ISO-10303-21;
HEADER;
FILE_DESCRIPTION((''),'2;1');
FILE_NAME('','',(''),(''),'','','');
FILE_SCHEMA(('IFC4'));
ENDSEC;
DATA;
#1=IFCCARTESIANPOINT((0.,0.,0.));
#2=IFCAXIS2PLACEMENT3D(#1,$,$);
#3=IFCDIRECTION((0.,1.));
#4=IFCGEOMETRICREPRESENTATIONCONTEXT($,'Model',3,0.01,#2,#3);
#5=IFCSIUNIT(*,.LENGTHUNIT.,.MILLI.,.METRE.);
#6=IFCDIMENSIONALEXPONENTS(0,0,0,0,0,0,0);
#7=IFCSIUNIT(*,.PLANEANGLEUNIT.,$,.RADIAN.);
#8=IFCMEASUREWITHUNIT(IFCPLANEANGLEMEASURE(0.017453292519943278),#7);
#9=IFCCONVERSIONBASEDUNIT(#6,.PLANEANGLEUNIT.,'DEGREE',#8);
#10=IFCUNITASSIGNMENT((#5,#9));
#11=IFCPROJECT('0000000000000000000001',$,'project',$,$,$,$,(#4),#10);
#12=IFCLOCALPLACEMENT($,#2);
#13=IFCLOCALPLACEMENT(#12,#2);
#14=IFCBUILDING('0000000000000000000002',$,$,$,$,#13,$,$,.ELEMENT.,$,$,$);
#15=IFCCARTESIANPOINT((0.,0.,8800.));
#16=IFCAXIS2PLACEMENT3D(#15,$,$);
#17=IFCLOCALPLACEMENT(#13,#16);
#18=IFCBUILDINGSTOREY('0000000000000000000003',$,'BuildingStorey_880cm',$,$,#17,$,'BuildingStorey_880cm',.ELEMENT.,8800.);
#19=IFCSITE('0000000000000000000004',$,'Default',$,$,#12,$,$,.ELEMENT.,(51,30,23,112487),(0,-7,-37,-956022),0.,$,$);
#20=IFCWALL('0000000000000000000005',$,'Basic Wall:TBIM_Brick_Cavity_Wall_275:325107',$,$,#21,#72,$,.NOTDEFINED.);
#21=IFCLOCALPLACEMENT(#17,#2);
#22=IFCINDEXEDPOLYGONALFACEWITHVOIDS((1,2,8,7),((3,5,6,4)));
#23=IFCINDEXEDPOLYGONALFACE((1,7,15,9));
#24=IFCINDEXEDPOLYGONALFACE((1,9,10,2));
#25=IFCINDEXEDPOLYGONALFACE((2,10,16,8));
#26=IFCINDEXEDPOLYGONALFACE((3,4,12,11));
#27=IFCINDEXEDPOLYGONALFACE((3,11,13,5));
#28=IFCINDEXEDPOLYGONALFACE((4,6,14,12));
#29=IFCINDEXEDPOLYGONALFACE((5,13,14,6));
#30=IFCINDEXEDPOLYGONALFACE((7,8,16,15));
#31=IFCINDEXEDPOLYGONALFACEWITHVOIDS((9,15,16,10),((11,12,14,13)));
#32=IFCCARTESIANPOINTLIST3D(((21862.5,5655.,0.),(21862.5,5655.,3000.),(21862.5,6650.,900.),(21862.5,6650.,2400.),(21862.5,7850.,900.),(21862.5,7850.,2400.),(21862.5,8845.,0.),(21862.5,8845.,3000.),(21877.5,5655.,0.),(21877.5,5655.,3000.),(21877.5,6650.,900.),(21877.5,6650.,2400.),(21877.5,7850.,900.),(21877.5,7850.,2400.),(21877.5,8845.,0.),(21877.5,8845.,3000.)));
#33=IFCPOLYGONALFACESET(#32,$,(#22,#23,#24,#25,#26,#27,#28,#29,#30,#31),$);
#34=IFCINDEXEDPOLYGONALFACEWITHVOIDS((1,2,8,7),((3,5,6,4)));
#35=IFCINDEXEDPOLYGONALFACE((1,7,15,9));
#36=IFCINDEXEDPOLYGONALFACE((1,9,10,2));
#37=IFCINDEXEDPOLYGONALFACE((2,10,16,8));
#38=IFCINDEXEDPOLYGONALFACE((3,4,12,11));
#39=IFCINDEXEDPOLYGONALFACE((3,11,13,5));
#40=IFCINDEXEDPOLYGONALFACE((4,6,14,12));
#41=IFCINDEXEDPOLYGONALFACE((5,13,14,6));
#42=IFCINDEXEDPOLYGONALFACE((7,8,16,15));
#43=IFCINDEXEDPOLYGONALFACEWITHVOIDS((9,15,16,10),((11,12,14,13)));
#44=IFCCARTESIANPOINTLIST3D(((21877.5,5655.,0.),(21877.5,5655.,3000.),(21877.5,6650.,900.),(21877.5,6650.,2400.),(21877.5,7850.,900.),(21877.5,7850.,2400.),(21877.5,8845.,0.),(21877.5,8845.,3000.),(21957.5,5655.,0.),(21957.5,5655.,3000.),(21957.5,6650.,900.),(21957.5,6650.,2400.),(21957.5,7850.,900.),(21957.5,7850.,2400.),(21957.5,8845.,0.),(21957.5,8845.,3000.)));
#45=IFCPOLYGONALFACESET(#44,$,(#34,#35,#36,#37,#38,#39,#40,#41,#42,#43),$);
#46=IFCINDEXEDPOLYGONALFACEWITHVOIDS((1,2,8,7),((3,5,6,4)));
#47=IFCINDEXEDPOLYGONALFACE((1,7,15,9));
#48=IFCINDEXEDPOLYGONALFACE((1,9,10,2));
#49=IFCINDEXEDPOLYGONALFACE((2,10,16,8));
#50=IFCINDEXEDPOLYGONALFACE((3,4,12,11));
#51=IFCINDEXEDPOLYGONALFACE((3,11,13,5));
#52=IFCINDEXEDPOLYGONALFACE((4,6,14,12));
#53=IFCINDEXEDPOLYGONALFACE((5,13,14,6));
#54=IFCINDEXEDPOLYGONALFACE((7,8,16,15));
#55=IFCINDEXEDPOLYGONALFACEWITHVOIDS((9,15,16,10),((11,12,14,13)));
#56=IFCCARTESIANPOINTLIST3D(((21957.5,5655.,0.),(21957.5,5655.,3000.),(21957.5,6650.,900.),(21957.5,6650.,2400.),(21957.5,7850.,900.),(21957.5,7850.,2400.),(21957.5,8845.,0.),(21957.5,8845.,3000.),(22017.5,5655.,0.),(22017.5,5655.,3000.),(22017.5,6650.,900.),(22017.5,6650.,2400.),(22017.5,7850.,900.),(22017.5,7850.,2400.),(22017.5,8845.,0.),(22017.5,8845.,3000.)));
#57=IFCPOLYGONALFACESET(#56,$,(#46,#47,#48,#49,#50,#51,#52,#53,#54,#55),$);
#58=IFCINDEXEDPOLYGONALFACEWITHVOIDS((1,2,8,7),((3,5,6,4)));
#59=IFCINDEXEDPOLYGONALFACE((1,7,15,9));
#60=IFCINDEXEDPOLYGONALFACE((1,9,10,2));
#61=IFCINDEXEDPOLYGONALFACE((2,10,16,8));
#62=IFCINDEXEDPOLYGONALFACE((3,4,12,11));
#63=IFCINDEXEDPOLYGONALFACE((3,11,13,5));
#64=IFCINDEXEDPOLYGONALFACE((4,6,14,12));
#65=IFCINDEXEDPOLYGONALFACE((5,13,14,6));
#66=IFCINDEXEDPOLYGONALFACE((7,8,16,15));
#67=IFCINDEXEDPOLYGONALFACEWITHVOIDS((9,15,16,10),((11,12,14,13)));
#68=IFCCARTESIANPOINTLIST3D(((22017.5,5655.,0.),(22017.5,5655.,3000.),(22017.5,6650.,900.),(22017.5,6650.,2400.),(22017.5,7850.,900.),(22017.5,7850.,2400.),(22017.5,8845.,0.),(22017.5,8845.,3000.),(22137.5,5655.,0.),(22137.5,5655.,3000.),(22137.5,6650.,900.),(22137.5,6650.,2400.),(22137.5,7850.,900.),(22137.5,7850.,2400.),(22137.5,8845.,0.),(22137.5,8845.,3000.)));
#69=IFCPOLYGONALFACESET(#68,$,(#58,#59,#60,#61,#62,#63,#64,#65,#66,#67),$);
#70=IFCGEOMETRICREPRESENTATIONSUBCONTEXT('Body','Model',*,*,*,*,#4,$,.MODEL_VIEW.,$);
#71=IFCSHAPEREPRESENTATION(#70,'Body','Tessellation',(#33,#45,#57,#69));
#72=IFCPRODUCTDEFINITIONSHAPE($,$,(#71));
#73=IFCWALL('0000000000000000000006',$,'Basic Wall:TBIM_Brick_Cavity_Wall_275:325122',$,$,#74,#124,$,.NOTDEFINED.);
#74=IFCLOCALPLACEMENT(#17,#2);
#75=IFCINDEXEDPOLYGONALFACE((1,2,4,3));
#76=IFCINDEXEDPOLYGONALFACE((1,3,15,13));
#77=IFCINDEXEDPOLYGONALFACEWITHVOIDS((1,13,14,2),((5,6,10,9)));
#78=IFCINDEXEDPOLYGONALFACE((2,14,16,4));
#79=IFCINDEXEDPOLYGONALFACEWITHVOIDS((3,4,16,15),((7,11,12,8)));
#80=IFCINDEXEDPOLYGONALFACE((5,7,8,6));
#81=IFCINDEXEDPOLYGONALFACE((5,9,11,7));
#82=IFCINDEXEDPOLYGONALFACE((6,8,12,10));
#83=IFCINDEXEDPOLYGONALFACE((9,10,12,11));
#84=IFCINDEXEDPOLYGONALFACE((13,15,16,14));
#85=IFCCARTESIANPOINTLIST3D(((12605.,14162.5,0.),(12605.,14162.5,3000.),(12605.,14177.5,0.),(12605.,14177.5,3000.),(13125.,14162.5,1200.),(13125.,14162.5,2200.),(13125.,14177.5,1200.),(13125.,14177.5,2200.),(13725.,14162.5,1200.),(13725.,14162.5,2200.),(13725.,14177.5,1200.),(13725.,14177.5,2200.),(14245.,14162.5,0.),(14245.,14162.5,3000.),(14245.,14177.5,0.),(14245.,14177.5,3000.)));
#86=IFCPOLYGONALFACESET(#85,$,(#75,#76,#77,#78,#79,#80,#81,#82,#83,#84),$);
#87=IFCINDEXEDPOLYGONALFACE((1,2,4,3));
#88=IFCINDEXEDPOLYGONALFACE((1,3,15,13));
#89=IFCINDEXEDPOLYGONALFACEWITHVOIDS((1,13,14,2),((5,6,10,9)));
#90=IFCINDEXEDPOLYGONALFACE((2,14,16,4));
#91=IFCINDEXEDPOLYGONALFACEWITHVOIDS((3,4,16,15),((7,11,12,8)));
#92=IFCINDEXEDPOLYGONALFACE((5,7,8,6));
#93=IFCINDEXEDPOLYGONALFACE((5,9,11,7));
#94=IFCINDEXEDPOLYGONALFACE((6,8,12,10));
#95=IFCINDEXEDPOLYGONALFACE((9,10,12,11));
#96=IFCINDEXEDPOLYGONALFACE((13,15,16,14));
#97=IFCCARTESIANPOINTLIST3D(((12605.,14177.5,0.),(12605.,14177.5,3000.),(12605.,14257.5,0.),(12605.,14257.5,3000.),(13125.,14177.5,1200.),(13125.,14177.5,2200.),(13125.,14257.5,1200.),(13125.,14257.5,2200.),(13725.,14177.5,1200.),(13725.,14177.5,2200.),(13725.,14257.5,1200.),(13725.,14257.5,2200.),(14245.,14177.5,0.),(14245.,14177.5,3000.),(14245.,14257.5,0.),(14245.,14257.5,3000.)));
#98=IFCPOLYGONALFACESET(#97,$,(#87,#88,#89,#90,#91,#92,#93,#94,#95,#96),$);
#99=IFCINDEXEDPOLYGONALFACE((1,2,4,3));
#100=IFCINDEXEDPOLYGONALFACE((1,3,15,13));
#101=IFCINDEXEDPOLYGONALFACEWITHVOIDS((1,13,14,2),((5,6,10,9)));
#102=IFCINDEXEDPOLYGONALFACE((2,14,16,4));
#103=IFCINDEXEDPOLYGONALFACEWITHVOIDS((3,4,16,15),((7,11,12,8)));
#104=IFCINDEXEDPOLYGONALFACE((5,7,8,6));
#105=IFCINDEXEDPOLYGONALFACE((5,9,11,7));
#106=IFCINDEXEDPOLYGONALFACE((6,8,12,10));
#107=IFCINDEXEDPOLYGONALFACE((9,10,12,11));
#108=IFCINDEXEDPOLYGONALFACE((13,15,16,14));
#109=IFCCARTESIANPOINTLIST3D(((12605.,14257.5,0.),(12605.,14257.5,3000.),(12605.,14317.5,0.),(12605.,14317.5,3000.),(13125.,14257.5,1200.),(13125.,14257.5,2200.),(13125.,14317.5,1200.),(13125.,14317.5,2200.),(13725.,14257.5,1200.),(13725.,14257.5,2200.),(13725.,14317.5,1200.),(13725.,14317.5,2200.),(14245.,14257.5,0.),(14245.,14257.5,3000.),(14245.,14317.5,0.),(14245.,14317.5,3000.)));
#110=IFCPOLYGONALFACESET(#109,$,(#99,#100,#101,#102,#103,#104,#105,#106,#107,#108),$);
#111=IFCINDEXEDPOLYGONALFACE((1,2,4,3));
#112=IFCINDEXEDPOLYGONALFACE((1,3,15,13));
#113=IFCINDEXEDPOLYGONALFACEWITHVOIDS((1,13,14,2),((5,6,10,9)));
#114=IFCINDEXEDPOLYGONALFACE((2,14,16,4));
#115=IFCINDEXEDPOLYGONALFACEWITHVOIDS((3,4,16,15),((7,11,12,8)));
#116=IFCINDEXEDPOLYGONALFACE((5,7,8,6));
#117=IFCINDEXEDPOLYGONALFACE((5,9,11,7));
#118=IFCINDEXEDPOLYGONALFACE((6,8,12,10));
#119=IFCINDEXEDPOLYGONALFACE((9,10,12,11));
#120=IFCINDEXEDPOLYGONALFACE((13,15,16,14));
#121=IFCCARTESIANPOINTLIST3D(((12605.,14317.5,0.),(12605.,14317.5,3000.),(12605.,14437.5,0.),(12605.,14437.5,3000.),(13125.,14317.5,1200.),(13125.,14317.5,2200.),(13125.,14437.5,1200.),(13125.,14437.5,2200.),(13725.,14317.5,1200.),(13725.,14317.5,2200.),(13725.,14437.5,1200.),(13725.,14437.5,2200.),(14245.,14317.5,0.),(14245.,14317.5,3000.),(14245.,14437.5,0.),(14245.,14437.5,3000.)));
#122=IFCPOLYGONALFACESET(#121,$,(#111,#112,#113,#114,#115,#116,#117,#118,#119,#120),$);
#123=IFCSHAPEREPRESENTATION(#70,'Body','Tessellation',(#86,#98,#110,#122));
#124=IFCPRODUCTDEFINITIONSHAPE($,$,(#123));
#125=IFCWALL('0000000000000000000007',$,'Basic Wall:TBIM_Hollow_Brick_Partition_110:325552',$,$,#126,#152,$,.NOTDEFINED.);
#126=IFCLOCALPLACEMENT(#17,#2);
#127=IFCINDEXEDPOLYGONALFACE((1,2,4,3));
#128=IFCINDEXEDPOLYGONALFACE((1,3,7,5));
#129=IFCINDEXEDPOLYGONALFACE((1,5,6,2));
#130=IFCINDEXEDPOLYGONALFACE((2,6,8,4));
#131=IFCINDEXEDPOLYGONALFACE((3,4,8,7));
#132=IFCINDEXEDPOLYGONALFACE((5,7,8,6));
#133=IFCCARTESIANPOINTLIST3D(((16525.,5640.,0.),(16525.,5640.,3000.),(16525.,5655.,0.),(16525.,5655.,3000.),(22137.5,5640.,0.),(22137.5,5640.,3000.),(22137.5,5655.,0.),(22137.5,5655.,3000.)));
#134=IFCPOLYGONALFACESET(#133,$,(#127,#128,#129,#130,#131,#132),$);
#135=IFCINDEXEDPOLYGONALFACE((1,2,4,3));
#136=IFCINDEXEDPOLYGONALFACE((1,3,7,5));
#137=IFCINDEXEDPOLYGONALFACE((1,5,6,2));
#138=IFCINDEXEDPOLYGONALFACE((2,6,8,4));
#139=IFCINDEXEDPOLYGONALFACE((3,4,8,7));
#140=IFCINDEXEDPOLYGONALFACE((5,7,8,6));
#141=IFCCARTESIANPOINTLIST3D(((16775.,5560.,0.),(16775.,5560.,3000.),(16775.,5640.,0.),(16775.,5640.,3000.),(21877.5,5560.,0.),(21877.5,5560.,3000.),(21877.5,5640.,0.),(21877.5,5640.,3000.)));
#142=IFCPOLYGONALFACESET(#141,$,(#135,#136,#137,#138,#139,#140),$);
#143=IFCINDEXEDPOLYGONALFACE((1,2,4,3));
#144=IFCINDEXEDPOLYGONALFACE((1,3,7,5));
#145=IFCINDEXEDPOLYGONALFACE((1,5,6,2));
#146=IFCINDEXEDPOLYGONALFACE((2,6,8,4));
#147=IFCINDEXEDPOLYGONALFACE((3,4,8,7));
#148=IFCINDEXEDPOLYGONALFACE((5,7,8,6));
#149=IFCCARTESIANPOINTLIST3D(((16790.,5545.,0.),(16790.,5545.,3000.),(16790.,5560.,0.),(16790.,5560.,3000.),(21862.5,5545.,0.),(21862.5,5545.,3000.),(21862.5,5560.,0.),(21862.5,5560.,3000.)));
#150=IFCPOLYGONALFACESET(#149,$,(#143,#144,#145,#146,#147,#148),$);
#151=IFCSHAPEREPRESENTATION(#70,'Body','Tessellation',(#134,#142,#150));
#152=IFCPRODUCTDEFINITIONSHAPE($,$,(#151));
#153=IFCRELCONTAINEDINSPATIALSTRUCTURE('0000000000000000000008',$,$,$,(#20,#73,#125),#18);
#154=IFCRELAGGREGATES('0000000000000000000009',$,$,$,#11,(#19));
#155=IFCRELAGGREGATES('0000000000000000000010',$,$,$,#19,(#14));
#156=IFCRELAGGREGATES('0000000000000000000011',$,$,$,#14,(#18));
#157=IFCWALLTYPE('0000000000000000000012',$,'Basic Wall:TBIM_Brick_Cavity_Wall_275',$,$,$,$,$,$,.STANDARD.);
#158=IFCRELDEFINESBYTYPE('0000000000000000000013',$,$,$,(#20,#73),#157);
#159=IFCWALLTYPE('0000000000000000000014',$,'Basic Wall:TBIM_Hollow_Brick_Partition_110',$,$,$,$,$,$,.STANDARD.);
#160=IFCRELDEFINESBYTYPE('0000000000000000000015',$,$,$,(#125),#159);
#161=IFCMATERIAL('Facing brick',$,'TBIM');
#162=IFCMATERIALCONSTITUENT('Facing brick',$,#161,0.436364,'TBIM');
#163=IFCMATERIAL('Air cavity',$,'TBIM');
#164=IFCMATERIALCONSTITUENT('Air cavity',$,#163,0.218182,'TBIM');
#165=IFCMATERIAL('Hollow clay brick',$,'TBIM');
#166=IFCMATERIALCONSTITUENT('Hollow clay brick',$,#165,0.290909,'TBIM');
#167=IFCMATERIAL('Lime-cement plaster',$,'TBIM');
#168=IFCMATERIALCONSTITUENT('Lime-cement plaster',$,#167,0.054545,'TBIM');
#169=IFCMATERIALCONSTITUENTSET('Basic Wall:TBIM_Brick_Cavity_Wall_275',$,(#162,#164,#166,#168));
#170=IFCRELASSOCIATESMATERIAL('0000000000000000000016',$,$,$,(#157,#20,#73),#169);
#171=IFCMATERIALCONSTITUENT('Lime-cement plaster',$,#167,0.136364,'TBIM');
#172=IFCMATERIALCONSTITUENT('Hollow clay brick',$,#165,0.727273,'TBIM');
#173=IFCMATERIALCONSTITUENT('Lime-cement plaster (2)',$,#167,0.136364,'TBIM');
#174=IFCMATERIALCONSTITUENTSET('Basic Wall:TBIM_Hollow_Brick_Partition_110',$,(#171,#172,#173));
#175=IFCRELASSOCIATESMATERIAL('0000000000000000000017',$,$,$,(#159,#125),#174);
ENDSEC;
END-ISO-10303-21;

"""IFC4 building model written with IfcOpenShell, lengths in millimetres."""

from ifc_helpers import new_model, entity, si_unit, converted_unit, direction, frame, origin, place, context, subcontext, project, spatial, indexed_curve, outline, extrude, material, constituent, constituent_set, type_object, element, save


model = new_model("IFC4")

# Units and contexts
model_context = context("Model", 3, precision=0.01, world=origin(), true_north=direction((0.0, 1.0)))
body_context = subcontext(model_context, "Body", "Model", "MODEL_VIEW")
ifc_project = project(units=[si_unit("LENGTHUNIT", "METRE", prefix="MILLI"), converted_unit("PLANEANGLEUNIT", "DEGREE", entity("IfcPlaneAngleMeasure", 0.017453292519943278), si_unit("PLANEANGLEUNIT", "RADIAN"), dimensions=[0, 0, 0, 0, 0, 0, 0])], contexts=[model_context])

# Site, building, storey
site_placement = place(None, origin())
site = spatial("IfcSite", under=ifc_project, at=site_placement, Name="Default", CompositionType="ELEMENT", RefLatitude=(51, 30, 23, 112487), RefLongitude=(0, -7, -37, -956022), RefElevation=0.0)
building_placement = place(site_placement, origin())
building = spatial("IfcBuilding", under=site, at=building_placement, CompositionType="ELEMENT")
storey_placement = place(building_placement, frame((0.0, 0.0, 8800.0)))
storey = spatial("IfcBuildingStorey", under=building, at=storey_placement, Name="BuildingStorey_880cm", LongName="BuildingStorey_880cm", CompositionType="ELEMENT", Elevation=8800.0)

# Walls, openings
ifc_material_1 = material(Name="Facing brick", Category="TBIM")
ifc_constituent_1 = constituent(ifc_material_1, Name="Facing brick", Category="TBIM", fraction=0.436364)
ifc_material_2 = material(Name="Air cavity", Category="TBIM")
ifc_constituent_2 = constituent(ifc_material_2, Name="Air cavity", Category="TBIM", fraction=0.218182)
ifc_material_3 = material(Name="Hollow clay brick", Category="TBIM")
ifc_constituent_3 = constituent(ifc_material_3, Name="Hollow clay brick", Category="TBIM", fraction=0.290909)
ifc_material_4 = material(Name="Lime-cement plaster", Category="TBIM")
ifc_constituent_4 = constituent(ifc_material_4, Name="Lime-cement plaster", Category="TBIM", fraction=0.054545)
ifc_constituent_set_1 = constituent_set(constituents=[ifc_constituent_1, ifc_constituent_2, ifc_constituent_3, ifc_constituent_4], Name="Basic Wall:TBIM_Brick_Cavity_Wall_275")
wall_type_1 = type_object("IfcWallType", Name="Basic Wall:TBIM_Brick_Cavity_Wall_275", PredefinedType="STANDARD", material=ifc_constituent_set_1)
wall_1_placement = place(storey_placement, frame((22000.0, 5655.0, 0.0), z_axis=(0.0, 0.0, 1.0), x_axis=(0.0, 1.0, 0.0)))
wall_1 = element("IfcWall", 1, at=wall_1_placement, inside=storey, type_object=wall_type_1, material=ifc_constituent_set_1, Name="Basic Wall:TBIM_Brick_Cavity_Wall_275:325107", PredefinedType="NOTDEFINED", context=body_context, shape_type="SweptSolid", body=[
    extrude(outline(indexed_curve([(-1595.0, -1500.0), (1595.0, -1500.0), (1595.0, 1500.0), (-1595.0, 1500.0), (-1595.0, -1500.0)], self_intersect=False), holes=[indexed_curve([(-600.0, 900.0), (600.0, 900.0), (600.0, -600.0), (-600.0, -600.0), (-600.0, 900.0)], self_intersect=False)]), frame((1595.0, 137.5, 1500.0), z_axis=(0.0, -1.0, 0.0), x_axis=(1.0, 0.0, 0.0)), (0.0, 0.0, 1.0), 15.0),
    extrude(outline(indexed_curve([(-1500.0, -1595.0), (1500.0, -1595.0), (1500.0, 1595.0), (-1500.0, 1595.0), (-1500.0, -1595.0)], self_intersect=False), holes=[indexed_curve([(900.0, 600.0), (900.0, -600.0), (-600.0, -600.0), (-600.0, 600.0), (900.0, 600.0)], self_intersect=False)]), frame((1595.0, 122.5, 1500.0), z_axis=(0.0, -1.0, 0.0), x_axis=(0.0, 0.0, 1.0)), (0.0, 0.0, 1.0), 80.0),
    extrude(outline(indexed_curve([(-1500.0, -1595.0), (1500.0, -1595.0), (1500.0, 1595.0), (-1500.0, 1595.0), (-1500.0, -1595.0)], self_intersect=False), holes=[indexed_curve([(900.0, 600.0), (900.0, -600.0), (-600.0, -600.0), (-600.0, 600.0), (900.0, 600.0)], self_intersect=False)]), frame((1595.0, 42.5, 1500.0), z_axis=(0.0, -1.0, 0.0), x_axis=(0.0, 0.0, 1.0)), (0.0, 0.0, 1.0), 60.0),
    extrude(outline(indexed_curve([(-1500.0, -1595.0), (1500.0, -1595.0), (1500.0, 1595.0), (-1500.0, 1595.0), (-1500.0, -1595.0)], self_intersect=False), holes=[indexed_curve([(900.0, 600.0), (900.0, -600.0), (-600.0, -600.0), (-600.0, 600.0), (900.0, 600.0)], self_intersect=False)]), frame((1595.0, -17.5, 1500.0), z_axis=(0.0, -1.0, 0.0), x_axis=(0.0, 0.0, 1.0)), (0.0, 0.0, 1.0), 120.0),
])
opening_1_placement = place(wall_1_placement, frame((995.0, -137.5, 900.0)))
element("IfcOpeningElement", 2, at=opening_1_placement, cuts=wall_1, PredefinedType="OPENING", context=body_context, shape_type="SweptSolid", body=[
    extrude(outline(indexed_curve([(1500.0, 0.0), (1500.0, 1200.0), (0.0, 1200.0), (0.0, 0.0), (1500.0, 0.0)], self_intersect=False)), frame((0.0, 0.0, 0.0), z_axis=(0.0, 1.0, 0.0), x_axis=(0.0, 0.0, 1.0)), (0.0, 0.0, 1.0), 275.0),
])
wall_2_placement = place(storey_placement, frame((14245.0, 14300.0, 0.0), z_axis=(0.0, 0.0, 1.0), x_axis=(-1.0, 0.0, 0.0)))
wall_2 = element("IfcWall", 3, at=wall_2_placement, inside=storey, type_object=wall_type_1, material=ifc_constituent_set_1, Name="Basic Wall:TBIM_Brick_Cavity_Wall_275:325122", PredefinedType="NOTDEFINED", context=body_context, shape_type="SweptSolid", body=[
    extrude(outline(indexed_curve([(-820.0, -1500.0), (820.0, -1500.0), (820.0, 1500.0), (-820.0, 1500.0), (-820.0, -1500.0)], self_intersect=False), holes=[indexed_curve([(-300.0, 700.0), (300.0, 700.0), (300.0, -300.0), (-300.0, -300.0), (-300.0, 700.0)], self_intersect=False)]), frame((820.0, 137.5, 1500.0), z_axis=(0.0, -1.0, 0.0), x_axis=(1.0, 0.0, 0.0)), (0.0, 0.0, 1.0), 15.0),
    extrude(outline(indexed_curve([(-1500.0, -820.0), (1500.0, -820.0), (1500.0, 820.0), (-1500.0, 820.0), (-1500.0, -820.0)], self_intersect=False), holes=[indexed_curve([(700.0, 300.0), (700.0, -300.0), (-300.0, -300.0), (-300.0, 300.0), (700.0, 300.0)], self_intersect=False)]), frame((820.0, 122.5, 1500.0), z_axis=(0.0, -1.0, 0.0), x_axis=(0.0, 0.0, 1.0)), (0.0, 0.0, 1.0), 80.0),
    extrude(outline(indexed_curve([(-1500.0, -820.0), (1500.0, -820.0), (1500.0, 820.0), (-1500.0, 820.0), (-1500.0, -820.0)], self_intersect=False), holes=[indexed_curve([(700.0, 300.0), (700.0, -300.0), (-300.0, -300.0), (-300.0, 300.0), (700.0, 300.0)], self_intersect=False)]), frame((820.0, 42.5, 1500.0), z_axis=(0.0, -1.0, 0.0), x_axis=(0.0, 0.0, 1.0)), (0.0, 0.0, 1.0), 60.0),
    extrude(outline(indexed_curve([(-1500.0, -820.0), (1500.0, -820.0), (1500.0, 820.0), (-1500.0, 820.0), (-1500.0, -820.0)], self_intersect=False), holes=[indexed_curve([(700.0, 300.0), (700.0, -300.0), (-300.0, -300.0), (-300.0, 300.0), (700.0, 300.0)], self_intersect=False)]), frame((820.0, -17.5, 1500.0), z_axis=(0.0, -1.0, 0.0), x_axis=(0.0, 0.0, 1.0)), (0.0, 0.0, 1.0), 120.0),
])
opening_2_placement = place(wall_2_placement, frame((520.0, -137.5, 1200.0)))
element("IfcOpeningElement", 4, at=opening_2_placement, cuts=wall_2, PredefinedType="OPENING", context=body_context, shape_type="SweptSolid", body=[
    extrude(outline(indexed_curve([(1000.0, 0.0), (1000.0, 600.0), (0.0, 600.0), (0.0, 0.0), (1000.0, 0.0)], self_intersect=False)), frame((0.0, 0.0, 0.0), z_axis=(0.0, 1.0, 0.0), x_axis=(0.0, 0.0, 1.0)), (0.0, 0.0, 1.0), 275.0),
])
ifc_constituent_5 = constituent(ifc_material_4, Name="Lime-cement plaster", Category="TBIM", fraction=0.136364)
ifc_constituent_6 = constituent(ifc_material_3, Name="Hollow clay brick", Category="TBIM", fraction=0.727273)
ifc_constituent_7 = constituent(ifc_material_4, Name="Lime-cement plaster (2)", Category="TBIM", fraction=0.136364)
ifc_constituent_set_2 = constituent_set(constituents=[ifc_constituent_5, ifc_constituent_6, ifc_constituent_7], Name="Basic Wall:TBIM_Hollow_Brick_Partition_110")
wall_type_2 = type_object("IfcWallType", Name="Basic Wall:TBIM_Hollow_Brick_Partition_110", PredefinedType="STANDARD", material=ifc_constituent_set_2)

# Wall
wall_3_placement = place(storey_placement, frame((16790.0, 5600.0, 0.0)))
element("IfcWall", 5, at=wall_3_placement, inside=storey, type_object=wall_type_2, material=ifc_constituent_set_2, Name="Basic Wall:TBIM_Hollow_Brick_Partition_110:325552", PredefinedType="NOTDEFINED", context=body_context, shape_type="SweptSolid", body=[
    extrude(outline(indexed_curve([(-7.5, -2806.3), (7.5, -2806.3), (7.5, 2806.3), (-7.5, 2806.3), (-7.5, -2806.3)], self_intersect=False)), frame((2541.3, 47.5, 0.0), z_axis=(0.0, 0.0, 1.0), x_axis=(0.0, -1.0, 0.0)), (0.0, 0.0, 1.0), 3000.0),
    extrude(outline(indexed_curve([(-2551.3, -40.0), (2551.3, -40.0), (2551.3, 40.0), (-2551.3, 40.0), (-2551.3, -40.0)], self_intersect=False)), frame((2536.3, 0.0, 0.0)), (0.0, 0.0, 1.0), 3000.0),
    extrude(outline(indexed_curve([(-7.5, -2536.3), (7.5, -2536.3), (7.5, 2536.3), (-7.5, 2536.3), (-7.5, -2536.3)], self_intersect=False)), frame((2536.3, -47.5, 0.0), z_axis=(0.0, 0.0, 1.0), x_axis=(0.0, 1.0, 0.0)), (0.0, 0.0, 1.0), 3000.0),
])

save(model, "model.ifc")
